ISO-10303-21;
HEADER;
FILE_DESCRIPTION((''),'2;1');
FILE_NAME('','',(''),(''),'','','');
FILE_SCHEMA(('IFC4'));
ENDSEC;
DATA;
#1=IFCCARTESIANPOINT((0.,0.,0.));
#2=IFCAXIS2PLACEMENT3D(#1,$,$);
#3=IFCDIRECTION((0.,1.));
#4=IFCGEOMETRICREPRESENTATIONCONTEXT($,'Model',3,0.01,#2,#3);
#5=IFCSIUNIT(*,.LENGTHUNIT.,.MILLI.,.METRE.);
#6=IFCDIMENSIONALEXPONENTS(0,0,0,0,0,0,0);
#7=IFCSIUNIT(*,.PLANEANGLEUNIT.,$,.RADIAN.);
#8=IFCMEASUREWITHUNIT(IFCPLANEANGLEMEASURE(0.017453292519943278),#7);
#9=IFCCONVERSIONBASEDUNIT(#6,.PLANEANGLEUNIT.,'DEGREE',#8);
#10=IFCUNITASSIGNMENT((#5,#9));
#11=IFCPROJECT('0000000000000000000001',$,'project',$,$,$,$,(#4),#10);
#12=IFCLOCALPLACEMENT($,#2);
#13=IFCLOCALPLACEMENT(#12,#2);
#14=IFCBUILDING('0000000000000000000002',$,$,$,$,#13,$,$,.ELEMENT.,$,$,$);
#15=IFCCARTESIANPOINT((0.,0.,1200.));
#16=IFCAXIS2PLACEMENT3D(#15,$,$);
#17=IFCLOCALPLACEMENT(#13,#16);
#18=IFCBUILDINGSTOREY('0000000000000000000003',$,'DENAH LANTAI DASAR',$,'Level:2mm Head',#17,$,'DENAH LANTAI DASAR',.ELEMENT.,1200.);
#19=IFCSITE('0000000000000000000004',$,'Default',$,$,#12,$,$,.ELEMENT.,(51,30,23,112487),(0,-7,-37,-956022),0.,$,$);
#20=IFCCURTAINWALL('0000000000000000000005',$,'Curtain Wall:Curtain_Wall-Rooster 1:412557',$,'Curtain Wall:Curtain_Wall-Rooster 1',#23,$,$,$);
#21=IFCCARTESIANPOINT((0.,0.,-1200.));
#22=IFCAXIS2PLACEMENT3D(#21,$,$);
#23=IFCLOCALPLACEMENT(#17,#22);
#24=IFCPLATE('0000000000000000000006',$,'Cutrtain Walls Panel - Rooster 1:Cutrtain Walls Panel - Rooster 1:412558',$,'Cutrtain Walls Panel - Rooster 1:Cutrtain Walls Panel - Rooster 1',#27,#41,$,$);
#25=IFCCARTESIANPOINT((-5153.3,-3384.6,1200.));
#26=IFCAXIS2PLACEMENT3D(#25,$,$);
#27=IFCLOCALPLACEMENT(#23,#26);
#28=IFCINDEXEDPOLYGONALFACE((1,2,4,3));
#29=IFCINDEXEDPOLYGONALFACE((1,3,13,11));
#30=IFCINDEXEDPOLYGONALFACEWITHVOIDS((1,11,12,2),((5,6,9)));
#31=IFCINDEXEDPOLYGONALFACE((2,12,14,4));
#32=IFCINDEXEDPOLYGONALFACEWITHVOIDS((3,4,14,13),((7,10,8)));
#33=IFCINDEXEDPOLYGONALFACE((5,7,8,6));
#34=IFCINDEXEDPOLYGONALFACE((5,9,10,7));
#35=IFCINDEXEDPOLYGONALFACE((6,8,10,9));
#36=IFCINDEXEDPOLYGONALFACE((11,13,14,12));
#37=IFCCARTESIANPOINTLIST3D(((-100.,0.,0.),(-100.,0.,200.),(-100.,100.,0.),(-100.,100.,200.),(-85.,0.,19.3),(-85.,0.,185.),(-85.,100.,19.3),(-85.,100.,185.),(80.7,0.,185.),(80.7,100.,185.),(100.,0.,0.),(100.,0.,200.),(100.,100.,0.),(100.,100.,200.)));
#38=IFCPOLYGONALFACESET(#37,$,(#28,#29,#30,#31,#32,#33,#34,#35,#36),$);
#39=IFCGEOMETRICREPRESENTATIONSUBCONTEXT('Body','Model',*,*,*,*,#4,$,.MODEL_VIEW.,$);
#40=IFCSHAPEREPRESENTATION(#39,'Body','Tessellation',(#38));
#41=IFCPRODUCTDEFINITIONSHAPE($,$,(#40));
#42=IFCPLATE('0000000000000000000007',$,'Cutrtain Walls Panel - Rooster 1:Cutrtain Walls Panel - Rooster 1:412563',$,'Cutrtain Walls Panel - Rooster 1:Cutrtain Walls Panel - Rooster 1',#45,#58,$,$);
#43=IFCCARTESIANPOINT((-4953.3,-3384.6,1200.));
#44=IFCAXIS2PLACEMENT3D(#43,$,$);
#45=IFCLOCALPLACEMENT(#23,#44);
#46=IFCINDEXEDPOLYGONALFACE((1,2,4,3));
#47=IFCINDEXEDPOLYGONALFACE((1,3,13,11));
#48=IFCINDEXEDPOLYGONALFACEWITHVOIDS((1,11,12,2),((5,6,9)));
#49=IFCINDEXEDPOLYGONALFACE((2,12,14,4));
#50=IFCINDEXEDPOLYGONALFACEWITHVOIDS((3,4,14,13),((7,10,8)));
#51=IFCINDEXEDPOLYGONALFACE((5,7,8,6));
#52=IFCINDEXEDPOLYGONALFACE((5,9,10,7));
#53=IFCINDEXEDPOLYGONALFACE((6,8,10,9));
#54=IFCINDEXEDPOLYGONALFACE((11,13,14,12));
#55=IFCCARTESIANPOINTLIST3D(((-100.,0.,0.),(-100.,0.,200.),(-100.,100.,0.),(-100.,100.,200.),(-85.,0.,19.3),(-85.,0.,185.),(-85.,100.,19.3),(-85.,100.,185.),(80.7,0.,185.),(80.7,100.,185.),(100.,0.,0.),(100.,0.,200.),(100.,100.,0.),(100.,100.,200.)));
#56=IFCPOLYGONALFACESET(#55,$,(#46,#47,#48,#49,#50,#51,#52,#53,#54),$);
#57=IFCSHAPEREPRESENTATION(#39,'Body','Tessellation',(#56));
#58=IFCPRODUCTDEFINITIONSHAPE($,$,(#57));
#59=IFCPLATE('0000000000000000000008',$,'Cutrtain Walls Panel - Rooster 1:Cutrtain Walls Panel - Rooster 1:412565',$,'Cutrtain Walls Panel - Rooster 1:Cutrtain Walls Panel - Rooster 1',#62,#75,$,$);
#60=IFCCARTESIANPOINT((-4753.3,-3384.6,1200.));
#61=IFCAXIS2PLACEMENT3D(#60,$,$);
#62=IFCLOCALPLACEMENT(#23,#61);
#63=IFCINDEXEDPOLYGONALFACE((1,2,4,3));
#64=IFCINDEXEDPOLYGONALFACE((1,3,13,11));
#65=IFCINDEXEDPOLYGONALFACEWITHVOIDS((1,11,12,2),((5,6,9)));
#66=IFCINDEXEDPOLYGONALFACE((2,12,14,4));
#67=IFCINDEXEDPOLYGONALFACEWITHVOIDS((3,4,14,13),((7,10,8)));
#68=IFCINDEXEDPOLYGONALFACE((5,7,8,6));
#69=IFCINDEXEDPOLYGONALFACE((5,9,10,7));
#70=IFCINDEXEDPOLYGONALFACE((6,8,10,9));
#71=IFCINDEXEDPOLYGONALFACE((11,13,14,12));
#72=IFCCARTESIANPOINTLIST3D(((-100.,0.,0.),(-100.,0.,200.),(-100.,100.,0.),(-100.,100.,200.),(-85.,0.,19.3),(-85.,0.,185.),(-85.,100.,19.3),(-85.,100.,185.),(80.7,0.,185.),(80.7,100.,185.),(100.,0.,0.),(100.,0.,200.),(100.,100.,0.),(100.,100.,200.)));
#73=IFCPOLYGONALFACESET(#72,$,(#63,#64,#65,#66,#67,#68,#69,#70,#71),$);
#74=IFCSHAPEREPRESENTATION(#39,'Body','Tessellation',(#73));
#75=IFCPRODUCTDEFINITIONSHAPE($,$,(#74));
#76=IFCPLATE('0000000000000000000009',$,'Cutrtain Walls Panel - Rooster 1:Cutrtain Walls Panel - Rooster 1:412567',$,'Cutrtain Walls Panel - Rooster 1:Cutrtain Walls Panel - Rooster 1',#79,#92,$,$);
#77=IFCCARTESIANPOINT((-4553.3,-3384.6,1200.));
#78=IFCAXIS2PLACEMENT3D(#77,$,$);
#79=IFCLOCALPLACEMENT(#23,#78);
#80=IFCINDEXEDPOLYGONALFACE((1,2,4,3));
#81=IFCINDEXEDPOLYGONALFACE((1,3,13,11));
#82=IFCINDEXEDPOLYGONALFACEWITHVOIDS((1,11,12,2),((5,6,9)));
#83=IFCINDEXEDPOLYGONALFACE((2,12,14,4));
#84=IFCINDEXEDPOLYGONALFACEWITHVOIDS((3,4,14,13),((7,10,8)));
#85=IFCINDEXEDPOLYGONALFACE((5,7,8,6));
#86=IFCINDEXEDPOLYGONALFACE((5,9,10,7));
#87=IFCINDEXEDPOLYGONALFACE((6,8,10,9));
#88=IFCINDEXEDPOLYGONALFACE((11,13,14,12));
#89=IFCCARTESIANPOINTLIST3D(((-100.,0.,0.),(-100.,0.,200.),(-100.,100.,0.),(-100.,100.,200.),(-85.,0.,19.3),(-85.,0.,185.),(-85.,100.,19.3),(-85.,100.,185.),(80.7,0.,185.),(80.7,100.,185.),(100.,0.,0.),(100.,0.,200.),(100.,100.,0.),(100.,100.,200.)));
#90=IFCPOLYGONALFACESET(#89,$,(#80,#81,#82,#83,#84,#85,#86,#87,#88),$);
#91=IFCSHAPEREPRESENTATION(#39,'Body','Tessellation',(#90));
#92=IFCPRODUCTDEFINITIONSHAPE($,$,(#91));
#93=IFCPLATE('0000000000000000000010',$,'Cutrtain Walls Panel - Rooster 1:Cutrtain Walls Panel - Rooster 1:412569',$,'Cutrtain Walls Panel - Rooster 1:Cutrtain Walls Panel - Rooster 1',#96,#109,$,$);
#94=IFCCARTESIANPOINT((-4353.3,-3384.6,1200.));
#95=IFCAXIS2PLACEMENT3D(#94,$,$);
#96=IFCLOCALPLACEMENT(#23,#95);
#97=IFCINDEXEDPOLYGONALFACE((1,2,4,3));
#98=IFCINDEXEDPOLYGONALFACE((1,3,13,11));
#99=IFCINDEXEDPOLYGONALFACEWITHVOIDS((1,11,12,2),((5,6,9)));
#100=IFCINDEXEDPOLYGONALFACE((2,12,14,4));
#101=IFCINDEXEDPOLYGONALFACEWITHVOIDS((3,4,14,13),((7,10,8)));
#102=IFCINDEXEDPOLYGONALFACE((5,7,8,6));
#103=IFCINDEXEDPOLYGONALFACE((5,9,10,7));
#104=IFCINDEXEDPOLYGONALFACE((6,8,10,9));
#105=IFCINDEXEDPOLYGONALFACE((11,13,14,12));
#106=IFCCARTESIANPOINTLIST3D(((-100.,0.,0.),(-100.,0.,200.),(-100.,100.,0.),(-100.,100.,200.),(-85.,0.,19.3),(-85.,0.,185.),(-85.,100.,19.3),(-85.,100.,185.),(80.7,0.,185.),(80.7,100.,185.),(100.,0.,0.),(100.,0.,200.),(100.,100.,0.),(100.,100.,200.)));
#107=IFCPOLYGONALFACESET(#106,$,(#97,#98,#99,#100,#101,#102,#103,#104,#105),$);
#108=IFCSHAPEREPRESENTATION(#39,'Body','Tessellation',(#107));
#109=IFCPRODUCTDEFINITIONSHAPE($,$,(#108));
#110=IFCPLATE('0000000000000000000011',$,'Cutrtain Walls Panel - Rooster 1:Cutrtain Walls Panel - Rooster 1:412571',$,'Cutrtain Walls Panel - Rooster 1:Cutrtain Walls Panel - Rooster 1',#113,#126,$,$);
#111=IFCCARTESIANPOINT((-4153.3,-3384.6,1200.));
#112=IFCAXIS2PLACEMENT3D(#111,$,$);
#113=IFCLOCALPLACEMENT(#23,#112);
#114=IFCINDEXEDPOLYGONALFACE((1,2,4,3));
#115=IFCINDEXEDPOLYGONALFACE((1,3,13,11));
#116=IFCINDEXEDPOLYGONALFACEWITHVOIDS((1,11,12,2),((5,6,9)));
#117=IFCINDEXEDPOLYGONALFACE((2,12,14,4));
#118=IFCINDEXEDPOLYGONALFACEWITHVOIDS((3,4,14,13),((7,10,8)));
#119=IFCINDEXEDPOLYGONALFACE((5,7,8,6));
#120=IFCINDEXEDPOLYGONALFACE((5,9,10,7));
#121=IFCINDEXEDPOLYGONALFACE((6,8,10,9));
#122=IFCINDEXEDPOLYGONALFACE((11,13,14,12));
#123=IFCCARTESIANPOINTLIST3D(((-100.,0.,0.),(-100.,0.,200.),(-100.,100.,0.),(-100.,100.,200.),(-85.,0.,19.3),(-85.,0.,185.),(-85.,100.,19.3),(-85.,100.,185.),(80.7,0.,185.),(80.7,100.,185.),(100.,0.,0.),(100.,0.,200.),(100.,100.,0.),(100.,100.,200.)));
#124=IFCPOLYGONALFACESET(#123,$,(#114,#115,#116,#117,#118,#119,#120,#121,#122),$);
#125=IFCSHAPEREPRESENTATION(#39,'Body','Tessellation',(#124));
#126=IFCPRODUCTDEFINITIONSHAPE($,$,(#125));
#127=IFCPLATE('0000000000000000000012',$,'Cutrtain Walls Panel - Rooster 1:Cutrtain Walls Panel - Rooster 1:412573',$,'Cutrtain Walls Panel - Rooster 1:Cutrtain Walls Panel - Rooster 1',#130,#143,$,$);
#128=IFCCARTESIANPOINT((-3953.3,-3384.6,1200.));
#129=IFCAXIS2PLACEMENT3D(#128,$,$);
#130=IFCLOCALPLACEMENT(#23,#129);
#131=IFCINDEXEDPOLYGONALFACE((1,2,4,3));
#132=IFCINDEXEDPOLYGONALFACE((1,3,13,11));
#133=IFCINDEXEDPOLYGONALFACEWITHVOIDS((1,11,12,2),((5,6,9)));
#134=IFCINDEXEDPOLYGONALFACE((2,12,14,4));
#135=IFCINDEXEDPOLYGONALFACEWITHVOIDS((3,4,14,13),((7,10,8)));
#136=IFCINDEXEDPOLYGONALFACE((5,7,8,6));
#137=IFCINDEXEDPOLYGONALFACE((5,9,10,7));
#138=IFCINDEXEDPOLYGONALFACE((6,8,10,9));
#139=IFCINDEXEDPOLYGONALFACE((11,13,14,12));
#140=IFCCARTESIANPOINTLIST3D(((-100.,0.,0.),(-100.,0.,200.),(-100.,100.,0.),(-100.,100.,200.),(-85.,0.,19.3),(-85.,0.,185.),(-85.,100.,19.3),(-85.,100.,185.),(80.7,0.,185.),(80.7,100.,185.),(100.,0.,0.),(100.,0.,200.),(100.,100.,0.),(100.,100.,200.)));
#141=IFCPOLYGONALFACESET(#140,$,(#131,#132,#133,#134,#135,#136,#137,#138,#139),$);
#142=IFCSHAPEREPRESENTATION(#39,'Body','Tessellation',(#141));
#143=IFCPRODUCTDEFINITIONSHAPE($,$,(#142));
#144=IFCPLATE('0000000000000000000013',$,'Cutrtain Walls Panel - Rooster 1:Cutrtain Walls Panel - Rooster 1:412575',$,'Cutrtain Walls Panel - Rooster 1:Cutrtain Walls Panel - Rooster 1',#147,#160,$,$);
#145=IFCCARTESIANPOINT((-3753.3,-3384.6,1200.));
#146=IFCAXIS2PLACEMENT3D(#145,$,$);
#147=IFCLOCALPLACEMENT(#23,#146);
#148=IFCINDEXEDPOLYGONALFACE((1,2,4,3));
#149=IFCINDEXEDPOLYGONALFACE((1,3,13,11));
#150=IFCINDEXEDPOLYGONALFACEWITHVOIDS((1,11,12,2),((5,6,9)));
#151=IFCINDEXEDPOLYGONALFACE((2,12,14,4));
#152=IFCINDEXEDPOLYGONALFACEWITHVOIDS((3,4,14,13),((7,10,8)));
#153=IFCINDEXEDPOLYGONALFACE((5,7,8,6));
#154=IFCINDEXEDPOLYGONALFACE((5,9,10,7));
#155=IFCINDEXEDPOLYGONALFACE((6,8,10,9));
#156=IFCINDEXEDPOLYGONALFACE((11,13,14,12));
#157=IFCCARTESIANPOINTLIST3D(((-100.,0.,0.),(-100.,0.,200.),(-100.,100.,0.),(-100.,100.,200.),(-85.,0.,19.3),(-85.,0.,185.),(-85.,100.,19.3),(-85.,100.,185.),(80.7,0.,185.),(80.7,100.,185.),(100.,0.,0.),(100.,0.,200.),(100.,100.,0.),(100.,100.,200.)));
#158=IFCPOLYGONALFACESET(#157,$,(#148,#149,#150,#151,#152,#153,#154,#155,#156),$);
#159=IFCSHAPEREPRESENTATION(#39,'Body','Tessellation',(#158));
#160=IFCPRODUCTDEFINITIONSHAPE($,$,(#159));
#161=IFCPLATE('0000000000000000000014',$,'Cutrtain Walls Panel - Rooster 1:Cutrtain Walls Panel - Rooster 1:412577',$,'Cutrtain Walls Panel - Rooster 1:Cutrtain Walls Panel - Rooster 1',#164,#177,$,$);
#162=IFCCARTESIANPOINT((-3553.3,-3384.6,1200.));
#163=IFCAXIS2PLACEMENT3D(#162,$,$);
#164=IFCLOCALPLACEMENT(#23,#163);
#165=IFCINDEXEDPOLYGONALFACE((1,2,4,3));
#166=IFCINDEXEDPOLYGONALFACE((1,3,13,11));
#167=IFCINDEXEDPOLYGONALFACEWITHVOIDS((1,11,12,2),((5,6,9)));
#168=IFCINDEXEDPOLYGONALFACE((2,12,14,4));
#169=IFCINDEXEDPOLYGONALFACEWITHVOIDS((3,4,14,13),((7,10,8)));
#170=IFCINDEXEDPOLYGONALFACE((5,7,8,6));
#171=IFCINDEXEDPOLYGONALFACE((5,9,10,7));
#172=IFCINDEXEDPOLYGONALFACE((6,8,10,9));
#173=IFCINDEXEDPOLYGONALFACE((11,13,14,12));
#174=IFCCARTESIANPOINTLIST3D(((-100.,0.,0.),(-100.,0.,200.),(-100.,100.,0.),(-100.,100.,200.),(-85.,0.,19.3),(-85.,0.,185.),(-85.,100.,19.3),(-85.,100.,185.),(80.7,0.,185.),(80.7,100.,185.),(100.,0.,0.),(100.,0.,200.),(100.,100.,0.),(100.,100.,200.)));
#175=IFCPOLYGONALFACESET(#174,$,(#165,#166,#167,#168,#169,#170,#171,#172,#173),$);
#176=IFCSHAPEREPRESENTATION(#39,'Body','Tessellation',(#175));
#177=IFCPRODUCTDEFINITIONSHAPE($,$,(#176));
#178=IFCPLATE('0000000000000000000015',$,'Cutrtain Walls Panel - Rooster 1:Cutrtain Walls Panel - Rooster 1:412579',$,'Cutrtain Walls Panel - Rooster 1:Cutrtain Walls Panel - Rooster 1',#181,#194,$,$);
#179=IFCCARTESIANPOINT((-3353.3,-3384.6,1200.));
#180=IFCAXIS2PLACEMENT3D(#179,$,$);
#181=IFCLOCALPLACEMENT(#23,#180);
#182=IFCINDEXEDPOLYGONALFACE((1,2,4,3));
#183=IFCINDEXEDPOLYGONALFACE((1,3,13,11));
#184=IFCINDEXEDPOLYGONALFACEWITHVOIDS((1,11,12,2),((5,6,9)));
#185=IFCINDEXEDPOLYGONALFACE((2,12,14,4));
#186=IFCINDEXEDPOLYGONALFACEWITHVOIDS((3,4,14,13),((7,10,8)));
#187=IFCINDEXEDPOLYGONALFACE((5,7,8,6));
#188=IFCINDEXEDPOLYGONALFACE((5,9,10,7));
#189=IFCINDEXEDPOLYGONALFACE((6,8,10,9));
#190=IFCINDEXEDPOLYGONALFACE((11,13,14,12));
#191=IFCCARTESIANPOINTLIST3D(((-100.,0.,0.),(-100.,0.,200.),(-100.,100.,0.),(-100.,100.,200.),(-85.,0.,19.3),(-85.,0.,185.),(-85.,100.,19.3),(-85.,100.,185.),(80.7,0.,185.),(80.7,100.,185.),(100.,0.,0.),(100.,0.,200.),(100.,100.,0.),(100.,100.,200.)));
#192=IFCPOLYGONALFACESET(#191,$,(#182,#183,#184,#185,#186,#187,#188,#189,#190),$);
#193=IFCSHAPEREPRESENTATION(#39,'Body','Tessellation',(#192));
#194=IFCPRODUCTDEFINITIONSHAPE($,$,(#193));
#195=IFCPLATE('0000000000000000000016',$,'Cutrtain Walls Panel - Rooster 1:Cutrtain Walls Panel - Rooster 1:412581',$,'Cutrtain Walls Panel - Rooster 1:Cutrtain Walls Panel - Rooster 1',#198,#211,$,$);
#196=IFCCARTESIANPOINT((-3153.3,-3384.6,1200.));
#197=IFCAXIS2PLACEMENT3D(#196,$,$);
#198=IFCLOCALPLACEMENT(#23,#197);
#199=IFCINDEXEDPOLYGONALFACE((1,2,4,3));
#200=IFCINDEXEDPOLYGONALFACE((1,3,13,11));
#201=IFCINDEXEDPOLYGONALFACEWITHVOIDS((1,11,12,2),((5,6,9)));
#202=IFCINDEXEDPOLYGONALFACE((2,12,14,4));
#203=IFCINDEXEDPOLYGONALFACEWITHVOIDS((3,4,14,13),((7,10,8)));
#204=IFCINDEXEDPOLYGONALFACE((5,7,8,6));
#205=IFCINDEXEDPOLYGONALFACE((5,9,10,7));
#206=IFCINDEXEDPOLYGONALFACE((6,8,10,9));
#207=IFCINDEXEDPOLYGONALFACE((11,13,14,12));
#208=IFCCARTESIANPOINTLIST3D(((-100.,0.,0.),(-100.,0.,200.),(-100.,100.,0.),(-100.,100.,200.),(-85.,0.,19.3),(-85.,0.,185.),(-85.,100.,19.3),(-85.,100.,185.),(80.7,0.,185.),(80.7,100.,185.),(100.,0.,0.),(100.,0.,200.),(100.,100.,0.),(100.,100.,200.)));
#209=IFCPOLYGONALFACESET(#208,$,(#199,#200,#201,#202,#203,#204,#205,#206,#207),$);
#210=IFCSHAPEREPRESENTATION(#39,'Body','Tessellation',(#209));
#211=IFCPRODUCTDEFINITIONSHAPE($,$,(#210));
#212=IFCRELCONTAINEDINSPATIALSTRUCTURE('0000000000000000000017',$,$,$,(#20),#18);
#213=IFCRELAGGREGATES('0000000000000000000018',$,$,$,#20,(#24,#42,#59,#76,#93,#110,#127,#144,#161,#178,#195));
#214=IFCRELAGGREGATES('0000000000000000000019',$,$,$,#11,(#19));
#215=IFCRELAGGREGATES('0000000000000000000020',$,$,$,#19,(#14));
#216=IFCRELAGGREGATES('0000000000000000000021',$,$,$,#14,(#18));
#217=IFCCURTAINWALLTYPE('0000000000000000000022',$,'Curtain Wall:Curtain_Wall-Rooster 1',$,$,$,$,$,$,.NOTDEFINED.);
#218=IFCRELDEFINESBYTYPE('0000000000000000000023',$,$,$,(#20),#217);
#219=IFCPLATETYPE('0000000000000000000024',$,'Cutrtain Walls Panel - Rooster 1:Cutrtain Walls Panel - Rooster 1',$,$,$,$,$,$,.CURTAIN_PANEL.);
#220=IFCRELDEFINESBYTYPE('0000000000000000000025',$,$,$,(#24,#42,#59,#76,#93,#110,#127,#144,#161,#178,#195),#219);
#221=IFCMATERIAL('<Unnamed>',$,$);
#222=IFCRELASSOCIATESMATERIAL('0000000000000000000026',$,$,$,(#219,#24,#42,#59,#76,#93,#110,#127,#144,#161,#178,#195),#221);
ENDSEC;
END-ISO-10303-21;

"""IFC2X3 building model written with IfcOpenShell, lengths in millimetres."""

from ifc_helpers import new_model, entity, si_unit, converted_unit, direction, frame, origin, place, context, subcontext, project, spatial, polyline, outline, extrude, source, transform, mapped, material, type_object, type_shapes, element, aggregate, save


model = new_model("IFC2X3")

# Units and contexts
model_context = context("Model", 3, precision=0.01, world=origin(), true_north=direction((0.0, 1.0)))
body_context = subcontext(model_context, "Body", "Model", "MODEL_VIEW")
ifc_project = project(units=[si_unit("LENGTHUNIT", "METRE", prefix="MILLI"), converted_unit("PLANEANGLEUNIT", "DEGREE", entity("IfcPlaneAngleMeasure", 0.017453292519943278), si_unit("PLANEANGLEUNIT", "RADIAN"), dimensions=[0, 0, 0, 0, 0, 0, 0])], contexts=[model_context])

# Site, building, storey
site_placement = place(None, origin())
site = spatial("IfcSite", under=ifc_project, at=site_placement, Name="Default", CompositionType="ELEMENT", RefLatitude=(51, 30, 23, 112487), RefLongitude=(0, -7, -37, -956022), RefElevation=0.0)
building_placement = place(site_placement, origin())
building = spatial("IfcBuilding", under=site, at=building_placement, CompositionType="ELEMENT")
storey_placement = place(building_placement, frame((0.0, 0.0, 1200.0)))
storey = spatial("IfcBuildingStorey", under=building, at=storey_placement, Name="DENAH LANTAI DASAR", ObjectType="Level:2mm Head", LongName="DENAH LANTAI DASAR", CompositionType="ELEMENT", Elevation=1200.0)

# Curtain wall, plates
curtain_wall_type = type_object("IfcCurtainWallType", Name="Curtain Wall:Curtain_Wall-Rooster 1", PredefinedType="NOTDEFINED")
curtain_wall_placement = place(storey_placement, frame((0.0, 0.0, -1200.0)))
curtain_wall = element("IfcCurtainWall", 1, at=curtain_wall_placement, inside=storey, type_object=curtain_wall_type, Name="Curtain Wall:Curtain_Wall-Rooster 1:412557", ObjectType="Curtain Wall:Curtain_Wall-Rooster 1")
ifc_material = material(Name="<Unnamed>")
plate_type = type_object("IfcPlateType", Name="Cutrtain Walls Panel - Rooster 1:Cutrtain Walls Panel - Rooster 1", PredefinedType="CURTAIN_PANEL", material=ifc_material)
shared_shape = source(origin(), body_context, "Body", "SweptSolid", [
    extrude(outline(polyline([(-100.0, -100.0), (100.0, -100.0), (100.0, 100.0), (-100.0, 100.0), (-100.0, -100.0)]), holes=[polyline([(80.7, 85.0), (-85.0, -80.7), (-85.0, 85.0), (80.7, 85.0)])]), frame((0.0, 0.0, 100.0), z_axis=(0.0, 1.0, 0.0), x_axis=(0.0, 0.0, -1.0)), (0.0, 0.0, 1.0), 100.0),
])
type_shapes(plate_type, [shared_shape])
plate_1_placement = place(curtain_wall_placement, frame((-5153.3, -3384.6, 1200.0)))
plate_1 = element("IfcPlate", 2, at=plate_1_placement, type_object=plate_type, material=ifc_material, Name="Cutrtain Walls Panel - Rooster 1:Cutrtain Walls Panel - Rooster 1:412558", ObjectType="Cutrtain Walls Panel - Rooster 1:Cutrtain Walls Panel - Rooster 1", context=body_context, shape_type="MappedRepresentation", body=[
    mapped(shared_shape, transform((0.0, 0.0, 0.0), scale=1.0)),
])
plate_2_placement = place(curtain_wall_placement, frame((-4953.3, -3384.6, 1200.0)))
plate_2 = element("IfcPlate", 3, at=plate_2_placement, type_object=plate_type, material=ifc_material, Name="Cutrtain Walls Panel - Rooster 1:Cutrtain Walls Panel - Rooster 1:412563", ObjectType="Cutrtain Walls Panel - Rooster 1:Cutrtain Walls Panel - Rooster 1", context=body_context, shape_type="MappedRepresentation", body=[
    mapped(shared_shape, transform((0.0, 0.0, 0.0), scale=1.0)),
])
plate_3_placement = place(curtain_wall_placement, frame((-4753.3, -3384.6, 1200.0)))
plate_3 = element("IfcPlate", 4, at=plate_3_placement, type_object=plate_type, material=ifc_material, Name="Cutrtain Walls Panel - Rooster 1:Cutrtain Walls Panel - Rooster 1:412565", ObjectType="Cutrtain Walls Panel - Rooster 1:Cutrtain Walls Panel - Rooster 1", context=body_context, shape_type="MappedRepresentation", body=[
    mapped(shared_shape, transform((0.0, 0.0, 0.0), scale=1.0)),
])
plate_4_placement = place(curtain_wall_placement, frame((-4553.3, -3384.6, 1200.0)))
plate_4 = element("IfcPlate", 5, at=plate_4_placement, type_object=plate_type, material=ifc_material, Name="Cutrtain Walls Panel - Rooster 1:Cutrtain Walls Panel - Rooster 1:412567", ObjectType="Cutrtain Walls Panel - Rooster 1:Cutrtain Walls Panel - Rooster 1", context=body_context, shape_type="MappedRepresentation", body=[
    mapped(shared_shape, transform((0.0, 0.0, 0.0), scale=1.0)),
])
plate_5_placement = place(curtain_wall_placement, frame((-4353.3, -3384.6, 1200.0)))
plate_5 = element("IfcPlate", 6, at=plate_5_placement, type_object=plate_type, material=ifc_material, Name="Cutrtain Walls Panel - Rooster 1:Cutrtain Walls Panel - Rooster 1:412569", ObjectType="Cutrtain Walls Panel - Rooster 1:Cutrtain Walls Panel - Rooster 1", context=body_context, shape_type="MappedRepresentation", body=[
    mapped(shared_shape, transform((0.0, 0.0, 0.0), scale=1.0)),
])
plate_6_placement = place(curtain_wall_placement, frame((-4153.3, -3384.6, 1200.0)))
plate_6 = element("IfcPlate", 7, at=plate_6_placement, type_object=plate_type, material=ifc_material, Name="Cutrtain Walls Panel - Rooster 1:Cutrtain Walls Panel - Rooster 1:412571", ObjectType="Cutrtain Walls Panel - Rooster 1:Cutrtain Walls Panel - Rooster 1", context=body_context, shape_type="MappedRepresentation", body=[
    mapped(shared_shape, transform((0.0, 0.0, 0.0), scale=1.0)),
])
plate_7_placement = place(curtain_wall_placement, frame((-3953.3, -3384.6, 1200.0)))
plate_7 = element("IfcPlate", 8, at=plate_7_placement, type_object=plate_type, material=ifc_material, Name="Cutrtain Walls Panel - Rooster 1:Cutrtain Walls Panel - Rooster 1:412573", ObjectType="Cutrtain Walls Panel - Rooster 1:Cutrtain Walls Panel - Rooster 1", context=body_context, shape_type="MappedRepresentation", body=[
    mapped(shared_shape, transform((0.0, 0.0, 0.0), scale=1.0)),
])
plate_8_placement = place(curtain_wall_placement, frame((-3753.3, -3384.6, 1200.0)))
plate_8 = element("IfcPlate", 9, at=plate_8_placement, type_object=plate_type, material=ifc_material, Name="Cutrtain Walls Panel - Rooster 1:Cutrtain Walls Panel - Rooster 1:412575", ObjectType="Cutrtain Walls Panel - Rooster 1:Cutrtain Walls Panel - Rooster 1", context=body_context, shape_type="MappedRepresentation", body=[
    mapped(shared_shape, transform((0.0, 0.0, 0.0), scale=1.0)),
])
plate_9_placement = place(curtain_wall_placement, frame((-3553.3, -3384.6, 1200.0)))
plate_9 = element("IfcPlate", 10, at=plate_9_placement, type_object=plate_type, material=ifc_material, Name="Cutrtain Walls Panel - Rooster 1:Cutrtain Walls Panel - Rooster 1:412577", ObjectType="Cutrtain Walls Panel - Rooster 1:Cutrtain Walls Panel - Rooster 1", context=body_context, shape_type="MappedRepresentation", body=[
    mapped(shared_shape, transform((0.0, 0.0, 0.0), scale=1.0)),
])
plate_10_placement = place(curtain_wall_placement, frame((-3353.3, -3384.6, 1200.0)))
plate_10 = element("IfcPlate", 11, at=plate_10_placement, type_object=plate_type, material=ifc_material, Name="Cutrtain Walls Panel - Rooster 1:Cutrtain Walls Panel - Rooster 1:412579", ObjectType="Cutrtain Walls Panel - Rooster 1:Cutrtain Walls Panel - Rooster 1", context=body_context, shape_type="MappedRepresentation", body=[
    mapped(shared_shape, transform((0.0, 0.0, 0.0), scale=1.0)),
])
plate_11_placement = place(curtain_wall_placement, frame((-3153.3, -3384.6, 1200.0)))
plate_11 = element("IfcPlate", 12, at=plate_11_placement, type_object=plate_type, material=ifc_material, Name="Cutrtain Walls Panel - Rooster 1:Cutrtain Walls Panel - Rooster 1:412581", ObjectType="Cutrtain Walls Panel - Rooster 1:Cutrtain Walls Panel - Rooster 1", context=body_context, shape_type="MappedRepresentation", body=[
    mapped(shared_shape, transform((0.0, 0.0, 0.0), scale=1.0)),
])
aggregate(curtain_wall, [plate_1, plate_2, plate_3, plate_4, plate_5, plate_6, plate_7, plate_8, plate_9, plate_10, plate_11])

save(model, "model.ifc")
